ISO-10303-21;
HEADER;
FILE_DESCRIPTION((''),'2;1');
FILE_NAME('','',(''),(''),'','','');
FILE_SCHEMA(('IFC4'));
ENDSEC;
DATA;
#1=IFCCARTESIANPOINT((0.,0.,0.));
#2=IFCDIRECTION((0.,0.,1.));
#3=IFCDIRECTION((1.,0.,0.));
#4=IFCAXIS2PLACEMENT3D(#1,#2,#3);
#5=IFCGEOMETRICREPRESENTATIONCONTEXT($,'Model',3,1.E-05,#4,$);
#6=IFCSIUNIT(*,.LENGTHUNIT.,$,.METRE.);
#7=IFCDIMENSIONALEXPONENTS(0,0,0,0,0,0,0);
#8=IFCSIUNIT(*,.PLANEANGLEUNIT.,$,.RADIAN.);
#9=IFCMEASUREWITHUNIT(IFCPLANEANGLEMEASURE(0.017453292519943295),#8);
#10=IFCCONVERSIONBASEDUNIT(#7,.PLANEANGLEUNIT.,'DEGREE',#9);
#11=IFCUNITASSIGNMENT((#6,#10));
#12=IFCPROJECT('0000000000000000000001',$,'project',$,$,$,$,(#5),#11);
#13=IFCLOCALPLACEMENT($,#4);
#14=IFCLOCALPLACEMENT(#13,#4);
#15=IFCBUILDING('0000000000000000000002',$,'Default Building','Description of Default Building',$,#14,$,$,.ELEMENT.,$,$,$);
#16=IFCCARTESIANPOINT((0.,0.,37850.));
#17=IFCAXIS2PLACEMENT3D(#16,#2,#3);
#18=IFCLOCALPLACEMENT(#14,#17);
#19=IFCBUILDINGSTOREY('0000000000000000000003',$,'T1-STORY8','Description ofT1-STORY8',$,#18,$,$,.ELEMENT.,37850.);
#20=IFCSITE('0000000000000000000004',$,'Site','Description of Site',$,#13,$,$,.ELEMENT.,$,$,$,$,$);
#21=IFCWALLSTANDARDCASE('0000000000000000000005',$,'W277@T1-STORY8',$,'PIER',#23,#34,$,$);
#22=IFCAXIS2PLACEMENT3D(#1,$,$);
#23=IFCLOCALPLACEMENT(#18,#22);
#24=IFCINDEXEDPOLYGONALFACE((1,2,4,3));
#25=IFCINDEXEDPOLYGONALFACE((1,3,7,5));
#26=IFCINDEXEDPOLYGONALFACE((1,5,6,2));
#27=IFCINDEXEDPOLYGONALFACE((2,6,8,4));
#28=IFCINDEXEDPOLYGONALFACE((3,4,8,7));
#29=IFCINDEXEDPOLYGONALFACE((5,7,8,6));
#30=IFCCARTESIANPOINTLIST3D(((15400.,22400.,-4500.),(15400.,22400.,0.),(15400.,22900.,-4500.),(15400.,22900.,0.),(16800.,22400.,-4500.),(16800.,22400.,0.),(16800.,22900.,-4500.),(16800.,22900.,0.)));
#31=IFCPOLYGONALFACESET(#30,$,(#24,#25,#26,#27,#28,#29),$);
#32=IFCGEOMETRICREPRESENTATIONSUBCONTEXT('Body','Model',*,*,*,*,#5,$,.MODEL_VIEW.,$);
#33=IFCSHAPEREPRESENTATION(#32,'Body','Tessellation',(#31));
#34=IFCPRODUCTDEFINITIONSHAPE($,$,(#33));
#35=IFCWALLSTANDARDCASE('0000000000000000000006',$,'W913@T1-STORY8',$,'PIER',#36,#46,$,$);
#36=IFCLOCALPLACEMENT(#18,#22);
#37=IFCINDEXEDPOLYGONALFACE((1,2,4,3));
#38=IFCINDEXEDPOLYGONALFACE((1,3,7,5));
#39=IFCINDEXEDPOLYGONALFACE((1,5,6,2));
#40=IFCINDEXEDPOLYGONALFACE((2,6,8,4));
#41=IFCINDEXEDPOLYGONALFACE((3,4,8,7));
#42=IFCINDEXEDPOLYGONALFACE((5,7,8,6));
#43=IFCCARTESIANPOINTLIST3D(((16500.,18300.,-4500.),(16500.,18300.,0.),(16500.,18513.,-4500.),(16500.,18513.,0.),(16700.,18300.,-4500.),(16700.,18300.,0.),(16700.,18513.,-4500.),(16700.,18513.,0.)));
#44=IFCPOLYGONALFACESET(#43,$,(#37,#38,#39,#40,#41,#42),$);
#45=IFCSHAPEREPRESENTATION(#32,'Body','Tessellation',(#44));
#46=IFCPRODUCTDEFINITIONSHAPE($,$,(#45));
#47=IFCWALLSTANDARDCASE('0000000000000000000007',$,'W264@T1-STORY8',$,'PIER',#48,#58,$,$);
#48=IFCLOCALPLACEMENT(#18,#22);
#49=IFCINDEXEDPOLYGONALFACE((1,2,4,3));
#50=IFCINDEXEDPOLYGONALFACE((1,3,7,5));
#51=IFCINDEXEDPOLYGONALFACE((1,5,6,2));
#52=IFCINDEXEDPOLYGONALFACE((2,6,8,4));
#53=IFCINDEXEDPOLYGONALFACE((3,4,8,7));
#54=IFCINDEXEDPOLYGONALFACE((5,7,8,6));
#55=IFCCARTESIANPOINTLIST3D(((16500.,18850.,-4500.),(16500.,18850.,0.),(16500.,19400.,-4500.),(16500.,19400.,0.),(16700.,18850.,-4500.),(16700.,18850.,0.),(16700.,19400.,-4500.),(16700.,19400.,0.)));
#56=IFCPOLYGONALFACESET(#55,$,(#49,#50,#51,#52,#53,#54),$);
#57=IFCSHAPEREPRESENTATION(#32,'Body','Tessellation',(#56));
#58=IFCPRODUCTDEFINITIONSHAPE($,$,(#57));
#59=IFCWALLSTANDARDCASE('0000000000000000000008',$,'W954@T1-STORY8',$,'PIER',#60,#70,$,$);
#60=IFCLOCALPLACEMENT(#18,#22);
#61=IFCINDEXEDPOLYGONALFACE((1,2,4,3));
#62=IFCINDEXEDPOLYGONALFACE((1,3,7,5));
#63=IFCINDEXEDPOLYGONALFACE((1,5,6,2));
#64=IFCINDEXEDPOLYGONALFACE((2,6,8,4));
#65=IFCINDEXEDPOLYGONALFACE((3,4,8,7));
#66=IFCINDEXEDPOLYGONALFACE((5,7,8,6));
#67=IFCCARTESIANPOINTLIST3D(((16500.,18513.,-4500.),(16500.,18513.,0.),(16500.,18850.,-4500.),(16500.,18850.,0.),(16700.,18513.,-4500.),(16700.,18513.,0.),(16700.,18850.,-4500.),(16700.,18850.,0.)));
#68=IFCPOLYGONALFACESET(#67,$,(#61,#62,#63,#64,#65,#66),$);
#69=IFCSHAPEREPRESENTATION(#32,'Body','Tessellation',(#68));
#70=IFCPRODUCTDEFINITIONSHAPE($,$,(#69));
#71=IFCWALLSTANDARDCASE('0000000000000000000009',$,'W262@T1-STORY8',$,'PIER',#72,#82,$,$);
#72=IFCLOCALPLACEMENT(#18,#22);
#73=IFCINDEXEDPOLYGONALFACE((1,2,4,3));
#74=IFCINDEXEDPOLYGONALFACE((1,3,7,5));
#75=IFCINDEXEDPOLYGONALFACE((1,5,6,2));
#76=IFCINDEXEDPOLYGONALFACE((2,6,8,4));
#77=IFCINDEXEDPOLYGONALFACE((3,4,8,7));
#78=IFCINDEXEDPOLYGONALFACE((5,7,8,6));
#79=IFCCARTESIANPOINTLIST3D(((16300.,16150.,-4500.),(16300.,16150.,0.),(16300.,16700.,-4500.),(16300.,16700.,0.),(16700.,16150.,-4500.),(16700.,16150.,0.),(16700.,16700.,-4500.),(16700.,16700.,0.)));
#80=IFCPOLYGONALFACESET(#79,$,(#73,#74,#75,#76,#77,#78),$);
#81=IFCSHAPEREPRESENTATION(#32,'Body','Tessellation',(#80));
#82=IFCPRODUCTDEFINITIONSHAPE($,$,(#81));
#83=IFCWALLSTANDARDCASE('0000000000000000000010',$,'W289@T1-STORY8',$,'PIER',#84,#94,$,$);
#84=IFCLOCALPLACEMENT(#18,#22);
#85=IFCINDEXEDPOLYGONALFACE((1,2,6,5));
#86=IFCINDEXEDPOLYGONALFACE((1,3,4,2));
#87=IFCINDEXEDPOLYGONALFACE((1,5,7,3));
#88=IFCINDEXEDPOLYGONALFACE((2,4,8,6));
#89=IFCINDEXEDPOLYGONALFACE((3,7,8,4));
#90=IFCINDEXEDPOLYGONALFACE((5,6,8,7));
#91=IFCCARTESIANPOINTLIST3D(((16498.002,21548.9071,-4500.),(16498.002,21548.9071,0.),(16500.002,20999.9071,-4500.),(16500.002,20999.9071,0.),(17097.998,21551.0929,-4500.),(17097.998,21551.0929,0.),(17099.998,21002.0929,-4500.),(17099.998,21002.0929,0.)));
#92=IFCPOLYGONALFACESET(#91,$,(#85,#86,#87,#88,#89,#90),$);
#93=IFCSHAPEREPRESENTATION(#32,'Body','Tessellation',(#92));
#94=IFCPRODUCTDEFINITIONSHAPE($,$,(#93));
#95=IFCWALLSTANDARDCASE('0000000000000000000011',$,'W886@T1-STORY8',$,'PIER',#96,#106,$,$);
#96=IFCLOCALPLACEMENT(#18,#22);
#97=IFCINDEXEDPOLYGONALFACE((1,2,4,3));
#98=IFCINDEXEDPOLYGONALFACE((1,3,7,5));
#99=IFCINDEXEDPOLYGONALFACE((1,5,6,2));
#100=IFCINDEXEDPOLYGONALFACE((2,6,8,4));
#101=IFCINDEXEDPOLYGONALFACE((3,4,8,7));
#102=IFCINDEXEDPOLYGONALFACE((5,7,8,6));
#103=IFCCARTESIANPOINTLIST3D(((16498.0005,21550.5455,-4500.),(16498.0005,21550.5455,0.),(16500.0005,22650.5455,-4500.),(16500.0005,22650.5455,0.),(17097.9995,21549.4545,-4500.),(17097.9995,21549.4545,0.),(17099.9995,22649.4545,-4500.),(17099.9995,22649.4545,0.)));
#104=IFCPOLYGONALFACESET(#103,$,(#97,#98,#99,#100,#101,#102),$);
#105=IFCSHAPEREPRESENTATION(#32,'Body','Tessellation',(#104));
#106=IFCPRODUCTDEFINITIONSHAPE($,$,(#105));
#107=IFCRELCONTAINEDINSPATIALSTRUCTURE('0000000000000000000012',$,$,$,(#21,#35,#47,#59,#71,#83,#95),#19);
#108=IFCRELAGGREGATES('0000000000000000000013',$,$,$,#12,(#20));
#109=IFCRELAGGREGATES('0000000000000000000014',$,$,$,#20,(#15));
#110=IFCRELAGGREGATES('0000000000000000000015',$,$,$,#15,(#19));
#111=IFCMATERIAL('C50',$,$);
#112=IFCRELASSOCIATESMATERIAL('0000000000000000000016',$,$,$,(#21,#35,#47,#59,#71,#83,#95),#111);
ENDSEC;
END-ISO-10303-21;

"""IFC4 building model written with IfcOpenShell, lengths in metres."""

from ifc_helpers import new_model, entity, si_unit, converted_unit, frame, origin_with_axes, place, context, subcontext, project, spatial, indexed_curve, outline, extrude, material, element, save


model = new_model("IFC4")

# Units and contexts
model_context = context("Model", 3, precision=1e-05, world=origin_with_axes())
body_context = subcontext(model_context, "Body", "Model", "MODEL_VIEW")
ifc_project = project(units=[si_unit("LENGTHUNIT", "METRE"), converted_unit("PLANEANGLEUNIT", "DEGREE", entity("IfcPlaneAngleMeasure", 0.017453292519943295), si_unit("PLANEANGLEUNIT", "RADIAN"), dimensions=[0, 0, 0, 0, 0, 0, 0])], contexts=[model_context])

# Site, building, storey
site_placement = place(None, origin_with_axes())
site = spatial("IfcSite", under=ifc_project, at=site_placement, Name="Site", Description="Description of Site", CompositionType="ELEMENT")
building_placement = place(site_placement, origin_with_axes())
building = spatial("IfcBuilding", under=site, at=building_placement, Name="Default Building", Description="Description of Default Building", CompositionType="ELEMENT")
storey_placement = place(building_placement, frame((0.0, 0.0, 37850.0), z_axis=(0.0, 0.0, 1.0), x_axis=(1.0, 0.0, 0.0)))
storey = spatial("IfcBuildingStorey", under=building, at=storey_placement, Name="T1-STORY8", Description="Description ofT1-STORY8", CompositionType="ELEMENT", Elevation=37850.0)

# Shared definitions
ifc_material_1 = material(Name="C50")

# Walls
wall_1_placement = place(storey_placement, frame((15400.0, 22650.0, -4500.0), z_axis=(0.0, 0.0, 1.0), x_axis=(1.0, 0.0, 0.0)))
element("IfcWallStandardCase", 1, at=wall_1_placement, inside=storey, material=ifc_material_1, Name="W277@T1-STORY8", ObjectType="PIER", context=body_context, shape_type="SweptSolid", body=[
    extrude(outline(indexed_curve([(0.0, -250.0), (0.0, 250.0), (1400.0, 250.0), (1400.0, -250.0), (0.0, -250.0)], self_intersect=False)), origin_with_axes(), (0.0, 0.0, 1.0), 4500.0),
])
wall_2_placement = place(storey_placement, frame((16600.0, 18300.0, -4500.0), z_axis=(0.0, 0.0, 1.0), x_axis=(0.0, 1.0, 0.0)))
element("IfcWallStandardCase", 2, at=wall_2_placement, inside=storey, material=ifc_material_1, Name="W913@T1-STORY8", ObjectType="PIER", context=body_context, shape_type="SweptSolid", body=[
    extrude(outline(indexed_curve([(0.0, -100.0), (0.0, 100.0), (213.0, 100.0), (213.0, -100.0), (0.0, -100.0)], self_intersect=False)), origin_with_axes(), (0.0, 0.0, 1.0), 4500.0),
])
wall_3_placement = place(storey_placement, frame((16600.0, 18850.0, -4500.0), z_axis=(0.0, 0.0, 1.0), x_axis=(0.0, 1.0, 0.0)))
element("IfcWallStandardCase", 3, at=wall_3_placement, inside=storey, material=ifc_material_1, Name="W264@T1-STORY8", ObjectType="PIER", context=body_context, shape_type="SweptSolid", body=[
    extrude(outline(indexed_curve([(0.0, -100.0), (0.0, 100.0), (550.0, 100.0), (550.0, -100.0), (0.0, -100.0)], self_intersect=False)), origin_with_axes(), (0.0, 0.0, 1.0), 4500.0),
])
wall_4_placement = place(storey_placement, frame((16600.0, 18513.0, -4500.0), z_axis=(0.0, 0.0, 1.0), x_axis=(0.0, 1.0, 0.0)))
element("IfcWallStandardCase", 4, at=wall_4_placement, inside=storey, material=ifc_material_1, Name="W954@T1-STORY8", ObjectType="PIER", context=body_context, shape_type="SweptSolid", body=[
    extrude(outline(indexed_curve([(0.0, -100.0), (0.0, 100.0), (337.0, 100.0), (337.0, -100.0), (0.0, -100.0)], self_intersect=False)), origin_with_axes(), (0.0, 0.0, 1.0), 4500.0),
])
wall_5_placement = place(storey_placement, frame((16500.0, 16150.0, -4500.0), z_axis=(0.0, 0.0, 1.0), x_axis=(0.0, 1.0, 0.0)))
element("IfcWallStandardCase", 5, at=wall_5_placement, inside=storey, material=ifc_material_1, Name="W262@T1-STORY8", ObjectType="PIER", context=body_context, shape_type="SweptSolid", body=[
    extrude(outline(indexed_curve([(0.0, -200.0), (0.0, 200.0), (550.0, 200.0), (550.0, -200.0), (0.0, -200.0)], self_intersect=False)), origin_with_axes(), (0.0, 0.0, 1.0), 4500.0),
])
wall_6_placement = place(storey_placement, frame((16800.0, 21001.0, -4500.0), z_axis=(0.0, 0.0, 1.0), x_axis=(-0.003643, 0.999993, 0.0)))
element("IfcWallStandardCase", 6, at=wall_6_placement, inside=storey, material=ifc_material_1, Name="W289@T1-STORY8", ObjectType="PIER", context=body_context, shape_type="SweptSolid", body=[
    extrude(outline(indexed_curve([(0.0, -300.0), (0.0, 300.0), (549.0036, 300.0), (549.0036, -300.0), (0.0, -300.0)], self_intersect=False)), origin_with_axes(), (0.0, 0.0, 1.0), 4500.0),
])
wall_7_placement = place(storey_placement, frame((16798.0, 21550.0, -4500.0), z_axis=(0.0, 0.0, 1.0), x_axis=(0.001818, 0.999998, 0.0)))
element("IfcWallStandardCase", 7, at=wall_7_placement, inside=storey, material=ifc_material_1, Name="W886@T1-STORY8", ObjectType="PIER", context=body_context, shape_type="SweptSolid", body=[
    extrude(outline(indexed_curve([(0.0, -300.0), (0.0, 300.0), (1100.0018, 300.0), (1100.0018, -300.0), (0.0, -300.0)], self_intersect=False)), origin_with_axes(), (0.0, 0.0, 1.0), 4500.0),
])

save(model, "model.ifc")
